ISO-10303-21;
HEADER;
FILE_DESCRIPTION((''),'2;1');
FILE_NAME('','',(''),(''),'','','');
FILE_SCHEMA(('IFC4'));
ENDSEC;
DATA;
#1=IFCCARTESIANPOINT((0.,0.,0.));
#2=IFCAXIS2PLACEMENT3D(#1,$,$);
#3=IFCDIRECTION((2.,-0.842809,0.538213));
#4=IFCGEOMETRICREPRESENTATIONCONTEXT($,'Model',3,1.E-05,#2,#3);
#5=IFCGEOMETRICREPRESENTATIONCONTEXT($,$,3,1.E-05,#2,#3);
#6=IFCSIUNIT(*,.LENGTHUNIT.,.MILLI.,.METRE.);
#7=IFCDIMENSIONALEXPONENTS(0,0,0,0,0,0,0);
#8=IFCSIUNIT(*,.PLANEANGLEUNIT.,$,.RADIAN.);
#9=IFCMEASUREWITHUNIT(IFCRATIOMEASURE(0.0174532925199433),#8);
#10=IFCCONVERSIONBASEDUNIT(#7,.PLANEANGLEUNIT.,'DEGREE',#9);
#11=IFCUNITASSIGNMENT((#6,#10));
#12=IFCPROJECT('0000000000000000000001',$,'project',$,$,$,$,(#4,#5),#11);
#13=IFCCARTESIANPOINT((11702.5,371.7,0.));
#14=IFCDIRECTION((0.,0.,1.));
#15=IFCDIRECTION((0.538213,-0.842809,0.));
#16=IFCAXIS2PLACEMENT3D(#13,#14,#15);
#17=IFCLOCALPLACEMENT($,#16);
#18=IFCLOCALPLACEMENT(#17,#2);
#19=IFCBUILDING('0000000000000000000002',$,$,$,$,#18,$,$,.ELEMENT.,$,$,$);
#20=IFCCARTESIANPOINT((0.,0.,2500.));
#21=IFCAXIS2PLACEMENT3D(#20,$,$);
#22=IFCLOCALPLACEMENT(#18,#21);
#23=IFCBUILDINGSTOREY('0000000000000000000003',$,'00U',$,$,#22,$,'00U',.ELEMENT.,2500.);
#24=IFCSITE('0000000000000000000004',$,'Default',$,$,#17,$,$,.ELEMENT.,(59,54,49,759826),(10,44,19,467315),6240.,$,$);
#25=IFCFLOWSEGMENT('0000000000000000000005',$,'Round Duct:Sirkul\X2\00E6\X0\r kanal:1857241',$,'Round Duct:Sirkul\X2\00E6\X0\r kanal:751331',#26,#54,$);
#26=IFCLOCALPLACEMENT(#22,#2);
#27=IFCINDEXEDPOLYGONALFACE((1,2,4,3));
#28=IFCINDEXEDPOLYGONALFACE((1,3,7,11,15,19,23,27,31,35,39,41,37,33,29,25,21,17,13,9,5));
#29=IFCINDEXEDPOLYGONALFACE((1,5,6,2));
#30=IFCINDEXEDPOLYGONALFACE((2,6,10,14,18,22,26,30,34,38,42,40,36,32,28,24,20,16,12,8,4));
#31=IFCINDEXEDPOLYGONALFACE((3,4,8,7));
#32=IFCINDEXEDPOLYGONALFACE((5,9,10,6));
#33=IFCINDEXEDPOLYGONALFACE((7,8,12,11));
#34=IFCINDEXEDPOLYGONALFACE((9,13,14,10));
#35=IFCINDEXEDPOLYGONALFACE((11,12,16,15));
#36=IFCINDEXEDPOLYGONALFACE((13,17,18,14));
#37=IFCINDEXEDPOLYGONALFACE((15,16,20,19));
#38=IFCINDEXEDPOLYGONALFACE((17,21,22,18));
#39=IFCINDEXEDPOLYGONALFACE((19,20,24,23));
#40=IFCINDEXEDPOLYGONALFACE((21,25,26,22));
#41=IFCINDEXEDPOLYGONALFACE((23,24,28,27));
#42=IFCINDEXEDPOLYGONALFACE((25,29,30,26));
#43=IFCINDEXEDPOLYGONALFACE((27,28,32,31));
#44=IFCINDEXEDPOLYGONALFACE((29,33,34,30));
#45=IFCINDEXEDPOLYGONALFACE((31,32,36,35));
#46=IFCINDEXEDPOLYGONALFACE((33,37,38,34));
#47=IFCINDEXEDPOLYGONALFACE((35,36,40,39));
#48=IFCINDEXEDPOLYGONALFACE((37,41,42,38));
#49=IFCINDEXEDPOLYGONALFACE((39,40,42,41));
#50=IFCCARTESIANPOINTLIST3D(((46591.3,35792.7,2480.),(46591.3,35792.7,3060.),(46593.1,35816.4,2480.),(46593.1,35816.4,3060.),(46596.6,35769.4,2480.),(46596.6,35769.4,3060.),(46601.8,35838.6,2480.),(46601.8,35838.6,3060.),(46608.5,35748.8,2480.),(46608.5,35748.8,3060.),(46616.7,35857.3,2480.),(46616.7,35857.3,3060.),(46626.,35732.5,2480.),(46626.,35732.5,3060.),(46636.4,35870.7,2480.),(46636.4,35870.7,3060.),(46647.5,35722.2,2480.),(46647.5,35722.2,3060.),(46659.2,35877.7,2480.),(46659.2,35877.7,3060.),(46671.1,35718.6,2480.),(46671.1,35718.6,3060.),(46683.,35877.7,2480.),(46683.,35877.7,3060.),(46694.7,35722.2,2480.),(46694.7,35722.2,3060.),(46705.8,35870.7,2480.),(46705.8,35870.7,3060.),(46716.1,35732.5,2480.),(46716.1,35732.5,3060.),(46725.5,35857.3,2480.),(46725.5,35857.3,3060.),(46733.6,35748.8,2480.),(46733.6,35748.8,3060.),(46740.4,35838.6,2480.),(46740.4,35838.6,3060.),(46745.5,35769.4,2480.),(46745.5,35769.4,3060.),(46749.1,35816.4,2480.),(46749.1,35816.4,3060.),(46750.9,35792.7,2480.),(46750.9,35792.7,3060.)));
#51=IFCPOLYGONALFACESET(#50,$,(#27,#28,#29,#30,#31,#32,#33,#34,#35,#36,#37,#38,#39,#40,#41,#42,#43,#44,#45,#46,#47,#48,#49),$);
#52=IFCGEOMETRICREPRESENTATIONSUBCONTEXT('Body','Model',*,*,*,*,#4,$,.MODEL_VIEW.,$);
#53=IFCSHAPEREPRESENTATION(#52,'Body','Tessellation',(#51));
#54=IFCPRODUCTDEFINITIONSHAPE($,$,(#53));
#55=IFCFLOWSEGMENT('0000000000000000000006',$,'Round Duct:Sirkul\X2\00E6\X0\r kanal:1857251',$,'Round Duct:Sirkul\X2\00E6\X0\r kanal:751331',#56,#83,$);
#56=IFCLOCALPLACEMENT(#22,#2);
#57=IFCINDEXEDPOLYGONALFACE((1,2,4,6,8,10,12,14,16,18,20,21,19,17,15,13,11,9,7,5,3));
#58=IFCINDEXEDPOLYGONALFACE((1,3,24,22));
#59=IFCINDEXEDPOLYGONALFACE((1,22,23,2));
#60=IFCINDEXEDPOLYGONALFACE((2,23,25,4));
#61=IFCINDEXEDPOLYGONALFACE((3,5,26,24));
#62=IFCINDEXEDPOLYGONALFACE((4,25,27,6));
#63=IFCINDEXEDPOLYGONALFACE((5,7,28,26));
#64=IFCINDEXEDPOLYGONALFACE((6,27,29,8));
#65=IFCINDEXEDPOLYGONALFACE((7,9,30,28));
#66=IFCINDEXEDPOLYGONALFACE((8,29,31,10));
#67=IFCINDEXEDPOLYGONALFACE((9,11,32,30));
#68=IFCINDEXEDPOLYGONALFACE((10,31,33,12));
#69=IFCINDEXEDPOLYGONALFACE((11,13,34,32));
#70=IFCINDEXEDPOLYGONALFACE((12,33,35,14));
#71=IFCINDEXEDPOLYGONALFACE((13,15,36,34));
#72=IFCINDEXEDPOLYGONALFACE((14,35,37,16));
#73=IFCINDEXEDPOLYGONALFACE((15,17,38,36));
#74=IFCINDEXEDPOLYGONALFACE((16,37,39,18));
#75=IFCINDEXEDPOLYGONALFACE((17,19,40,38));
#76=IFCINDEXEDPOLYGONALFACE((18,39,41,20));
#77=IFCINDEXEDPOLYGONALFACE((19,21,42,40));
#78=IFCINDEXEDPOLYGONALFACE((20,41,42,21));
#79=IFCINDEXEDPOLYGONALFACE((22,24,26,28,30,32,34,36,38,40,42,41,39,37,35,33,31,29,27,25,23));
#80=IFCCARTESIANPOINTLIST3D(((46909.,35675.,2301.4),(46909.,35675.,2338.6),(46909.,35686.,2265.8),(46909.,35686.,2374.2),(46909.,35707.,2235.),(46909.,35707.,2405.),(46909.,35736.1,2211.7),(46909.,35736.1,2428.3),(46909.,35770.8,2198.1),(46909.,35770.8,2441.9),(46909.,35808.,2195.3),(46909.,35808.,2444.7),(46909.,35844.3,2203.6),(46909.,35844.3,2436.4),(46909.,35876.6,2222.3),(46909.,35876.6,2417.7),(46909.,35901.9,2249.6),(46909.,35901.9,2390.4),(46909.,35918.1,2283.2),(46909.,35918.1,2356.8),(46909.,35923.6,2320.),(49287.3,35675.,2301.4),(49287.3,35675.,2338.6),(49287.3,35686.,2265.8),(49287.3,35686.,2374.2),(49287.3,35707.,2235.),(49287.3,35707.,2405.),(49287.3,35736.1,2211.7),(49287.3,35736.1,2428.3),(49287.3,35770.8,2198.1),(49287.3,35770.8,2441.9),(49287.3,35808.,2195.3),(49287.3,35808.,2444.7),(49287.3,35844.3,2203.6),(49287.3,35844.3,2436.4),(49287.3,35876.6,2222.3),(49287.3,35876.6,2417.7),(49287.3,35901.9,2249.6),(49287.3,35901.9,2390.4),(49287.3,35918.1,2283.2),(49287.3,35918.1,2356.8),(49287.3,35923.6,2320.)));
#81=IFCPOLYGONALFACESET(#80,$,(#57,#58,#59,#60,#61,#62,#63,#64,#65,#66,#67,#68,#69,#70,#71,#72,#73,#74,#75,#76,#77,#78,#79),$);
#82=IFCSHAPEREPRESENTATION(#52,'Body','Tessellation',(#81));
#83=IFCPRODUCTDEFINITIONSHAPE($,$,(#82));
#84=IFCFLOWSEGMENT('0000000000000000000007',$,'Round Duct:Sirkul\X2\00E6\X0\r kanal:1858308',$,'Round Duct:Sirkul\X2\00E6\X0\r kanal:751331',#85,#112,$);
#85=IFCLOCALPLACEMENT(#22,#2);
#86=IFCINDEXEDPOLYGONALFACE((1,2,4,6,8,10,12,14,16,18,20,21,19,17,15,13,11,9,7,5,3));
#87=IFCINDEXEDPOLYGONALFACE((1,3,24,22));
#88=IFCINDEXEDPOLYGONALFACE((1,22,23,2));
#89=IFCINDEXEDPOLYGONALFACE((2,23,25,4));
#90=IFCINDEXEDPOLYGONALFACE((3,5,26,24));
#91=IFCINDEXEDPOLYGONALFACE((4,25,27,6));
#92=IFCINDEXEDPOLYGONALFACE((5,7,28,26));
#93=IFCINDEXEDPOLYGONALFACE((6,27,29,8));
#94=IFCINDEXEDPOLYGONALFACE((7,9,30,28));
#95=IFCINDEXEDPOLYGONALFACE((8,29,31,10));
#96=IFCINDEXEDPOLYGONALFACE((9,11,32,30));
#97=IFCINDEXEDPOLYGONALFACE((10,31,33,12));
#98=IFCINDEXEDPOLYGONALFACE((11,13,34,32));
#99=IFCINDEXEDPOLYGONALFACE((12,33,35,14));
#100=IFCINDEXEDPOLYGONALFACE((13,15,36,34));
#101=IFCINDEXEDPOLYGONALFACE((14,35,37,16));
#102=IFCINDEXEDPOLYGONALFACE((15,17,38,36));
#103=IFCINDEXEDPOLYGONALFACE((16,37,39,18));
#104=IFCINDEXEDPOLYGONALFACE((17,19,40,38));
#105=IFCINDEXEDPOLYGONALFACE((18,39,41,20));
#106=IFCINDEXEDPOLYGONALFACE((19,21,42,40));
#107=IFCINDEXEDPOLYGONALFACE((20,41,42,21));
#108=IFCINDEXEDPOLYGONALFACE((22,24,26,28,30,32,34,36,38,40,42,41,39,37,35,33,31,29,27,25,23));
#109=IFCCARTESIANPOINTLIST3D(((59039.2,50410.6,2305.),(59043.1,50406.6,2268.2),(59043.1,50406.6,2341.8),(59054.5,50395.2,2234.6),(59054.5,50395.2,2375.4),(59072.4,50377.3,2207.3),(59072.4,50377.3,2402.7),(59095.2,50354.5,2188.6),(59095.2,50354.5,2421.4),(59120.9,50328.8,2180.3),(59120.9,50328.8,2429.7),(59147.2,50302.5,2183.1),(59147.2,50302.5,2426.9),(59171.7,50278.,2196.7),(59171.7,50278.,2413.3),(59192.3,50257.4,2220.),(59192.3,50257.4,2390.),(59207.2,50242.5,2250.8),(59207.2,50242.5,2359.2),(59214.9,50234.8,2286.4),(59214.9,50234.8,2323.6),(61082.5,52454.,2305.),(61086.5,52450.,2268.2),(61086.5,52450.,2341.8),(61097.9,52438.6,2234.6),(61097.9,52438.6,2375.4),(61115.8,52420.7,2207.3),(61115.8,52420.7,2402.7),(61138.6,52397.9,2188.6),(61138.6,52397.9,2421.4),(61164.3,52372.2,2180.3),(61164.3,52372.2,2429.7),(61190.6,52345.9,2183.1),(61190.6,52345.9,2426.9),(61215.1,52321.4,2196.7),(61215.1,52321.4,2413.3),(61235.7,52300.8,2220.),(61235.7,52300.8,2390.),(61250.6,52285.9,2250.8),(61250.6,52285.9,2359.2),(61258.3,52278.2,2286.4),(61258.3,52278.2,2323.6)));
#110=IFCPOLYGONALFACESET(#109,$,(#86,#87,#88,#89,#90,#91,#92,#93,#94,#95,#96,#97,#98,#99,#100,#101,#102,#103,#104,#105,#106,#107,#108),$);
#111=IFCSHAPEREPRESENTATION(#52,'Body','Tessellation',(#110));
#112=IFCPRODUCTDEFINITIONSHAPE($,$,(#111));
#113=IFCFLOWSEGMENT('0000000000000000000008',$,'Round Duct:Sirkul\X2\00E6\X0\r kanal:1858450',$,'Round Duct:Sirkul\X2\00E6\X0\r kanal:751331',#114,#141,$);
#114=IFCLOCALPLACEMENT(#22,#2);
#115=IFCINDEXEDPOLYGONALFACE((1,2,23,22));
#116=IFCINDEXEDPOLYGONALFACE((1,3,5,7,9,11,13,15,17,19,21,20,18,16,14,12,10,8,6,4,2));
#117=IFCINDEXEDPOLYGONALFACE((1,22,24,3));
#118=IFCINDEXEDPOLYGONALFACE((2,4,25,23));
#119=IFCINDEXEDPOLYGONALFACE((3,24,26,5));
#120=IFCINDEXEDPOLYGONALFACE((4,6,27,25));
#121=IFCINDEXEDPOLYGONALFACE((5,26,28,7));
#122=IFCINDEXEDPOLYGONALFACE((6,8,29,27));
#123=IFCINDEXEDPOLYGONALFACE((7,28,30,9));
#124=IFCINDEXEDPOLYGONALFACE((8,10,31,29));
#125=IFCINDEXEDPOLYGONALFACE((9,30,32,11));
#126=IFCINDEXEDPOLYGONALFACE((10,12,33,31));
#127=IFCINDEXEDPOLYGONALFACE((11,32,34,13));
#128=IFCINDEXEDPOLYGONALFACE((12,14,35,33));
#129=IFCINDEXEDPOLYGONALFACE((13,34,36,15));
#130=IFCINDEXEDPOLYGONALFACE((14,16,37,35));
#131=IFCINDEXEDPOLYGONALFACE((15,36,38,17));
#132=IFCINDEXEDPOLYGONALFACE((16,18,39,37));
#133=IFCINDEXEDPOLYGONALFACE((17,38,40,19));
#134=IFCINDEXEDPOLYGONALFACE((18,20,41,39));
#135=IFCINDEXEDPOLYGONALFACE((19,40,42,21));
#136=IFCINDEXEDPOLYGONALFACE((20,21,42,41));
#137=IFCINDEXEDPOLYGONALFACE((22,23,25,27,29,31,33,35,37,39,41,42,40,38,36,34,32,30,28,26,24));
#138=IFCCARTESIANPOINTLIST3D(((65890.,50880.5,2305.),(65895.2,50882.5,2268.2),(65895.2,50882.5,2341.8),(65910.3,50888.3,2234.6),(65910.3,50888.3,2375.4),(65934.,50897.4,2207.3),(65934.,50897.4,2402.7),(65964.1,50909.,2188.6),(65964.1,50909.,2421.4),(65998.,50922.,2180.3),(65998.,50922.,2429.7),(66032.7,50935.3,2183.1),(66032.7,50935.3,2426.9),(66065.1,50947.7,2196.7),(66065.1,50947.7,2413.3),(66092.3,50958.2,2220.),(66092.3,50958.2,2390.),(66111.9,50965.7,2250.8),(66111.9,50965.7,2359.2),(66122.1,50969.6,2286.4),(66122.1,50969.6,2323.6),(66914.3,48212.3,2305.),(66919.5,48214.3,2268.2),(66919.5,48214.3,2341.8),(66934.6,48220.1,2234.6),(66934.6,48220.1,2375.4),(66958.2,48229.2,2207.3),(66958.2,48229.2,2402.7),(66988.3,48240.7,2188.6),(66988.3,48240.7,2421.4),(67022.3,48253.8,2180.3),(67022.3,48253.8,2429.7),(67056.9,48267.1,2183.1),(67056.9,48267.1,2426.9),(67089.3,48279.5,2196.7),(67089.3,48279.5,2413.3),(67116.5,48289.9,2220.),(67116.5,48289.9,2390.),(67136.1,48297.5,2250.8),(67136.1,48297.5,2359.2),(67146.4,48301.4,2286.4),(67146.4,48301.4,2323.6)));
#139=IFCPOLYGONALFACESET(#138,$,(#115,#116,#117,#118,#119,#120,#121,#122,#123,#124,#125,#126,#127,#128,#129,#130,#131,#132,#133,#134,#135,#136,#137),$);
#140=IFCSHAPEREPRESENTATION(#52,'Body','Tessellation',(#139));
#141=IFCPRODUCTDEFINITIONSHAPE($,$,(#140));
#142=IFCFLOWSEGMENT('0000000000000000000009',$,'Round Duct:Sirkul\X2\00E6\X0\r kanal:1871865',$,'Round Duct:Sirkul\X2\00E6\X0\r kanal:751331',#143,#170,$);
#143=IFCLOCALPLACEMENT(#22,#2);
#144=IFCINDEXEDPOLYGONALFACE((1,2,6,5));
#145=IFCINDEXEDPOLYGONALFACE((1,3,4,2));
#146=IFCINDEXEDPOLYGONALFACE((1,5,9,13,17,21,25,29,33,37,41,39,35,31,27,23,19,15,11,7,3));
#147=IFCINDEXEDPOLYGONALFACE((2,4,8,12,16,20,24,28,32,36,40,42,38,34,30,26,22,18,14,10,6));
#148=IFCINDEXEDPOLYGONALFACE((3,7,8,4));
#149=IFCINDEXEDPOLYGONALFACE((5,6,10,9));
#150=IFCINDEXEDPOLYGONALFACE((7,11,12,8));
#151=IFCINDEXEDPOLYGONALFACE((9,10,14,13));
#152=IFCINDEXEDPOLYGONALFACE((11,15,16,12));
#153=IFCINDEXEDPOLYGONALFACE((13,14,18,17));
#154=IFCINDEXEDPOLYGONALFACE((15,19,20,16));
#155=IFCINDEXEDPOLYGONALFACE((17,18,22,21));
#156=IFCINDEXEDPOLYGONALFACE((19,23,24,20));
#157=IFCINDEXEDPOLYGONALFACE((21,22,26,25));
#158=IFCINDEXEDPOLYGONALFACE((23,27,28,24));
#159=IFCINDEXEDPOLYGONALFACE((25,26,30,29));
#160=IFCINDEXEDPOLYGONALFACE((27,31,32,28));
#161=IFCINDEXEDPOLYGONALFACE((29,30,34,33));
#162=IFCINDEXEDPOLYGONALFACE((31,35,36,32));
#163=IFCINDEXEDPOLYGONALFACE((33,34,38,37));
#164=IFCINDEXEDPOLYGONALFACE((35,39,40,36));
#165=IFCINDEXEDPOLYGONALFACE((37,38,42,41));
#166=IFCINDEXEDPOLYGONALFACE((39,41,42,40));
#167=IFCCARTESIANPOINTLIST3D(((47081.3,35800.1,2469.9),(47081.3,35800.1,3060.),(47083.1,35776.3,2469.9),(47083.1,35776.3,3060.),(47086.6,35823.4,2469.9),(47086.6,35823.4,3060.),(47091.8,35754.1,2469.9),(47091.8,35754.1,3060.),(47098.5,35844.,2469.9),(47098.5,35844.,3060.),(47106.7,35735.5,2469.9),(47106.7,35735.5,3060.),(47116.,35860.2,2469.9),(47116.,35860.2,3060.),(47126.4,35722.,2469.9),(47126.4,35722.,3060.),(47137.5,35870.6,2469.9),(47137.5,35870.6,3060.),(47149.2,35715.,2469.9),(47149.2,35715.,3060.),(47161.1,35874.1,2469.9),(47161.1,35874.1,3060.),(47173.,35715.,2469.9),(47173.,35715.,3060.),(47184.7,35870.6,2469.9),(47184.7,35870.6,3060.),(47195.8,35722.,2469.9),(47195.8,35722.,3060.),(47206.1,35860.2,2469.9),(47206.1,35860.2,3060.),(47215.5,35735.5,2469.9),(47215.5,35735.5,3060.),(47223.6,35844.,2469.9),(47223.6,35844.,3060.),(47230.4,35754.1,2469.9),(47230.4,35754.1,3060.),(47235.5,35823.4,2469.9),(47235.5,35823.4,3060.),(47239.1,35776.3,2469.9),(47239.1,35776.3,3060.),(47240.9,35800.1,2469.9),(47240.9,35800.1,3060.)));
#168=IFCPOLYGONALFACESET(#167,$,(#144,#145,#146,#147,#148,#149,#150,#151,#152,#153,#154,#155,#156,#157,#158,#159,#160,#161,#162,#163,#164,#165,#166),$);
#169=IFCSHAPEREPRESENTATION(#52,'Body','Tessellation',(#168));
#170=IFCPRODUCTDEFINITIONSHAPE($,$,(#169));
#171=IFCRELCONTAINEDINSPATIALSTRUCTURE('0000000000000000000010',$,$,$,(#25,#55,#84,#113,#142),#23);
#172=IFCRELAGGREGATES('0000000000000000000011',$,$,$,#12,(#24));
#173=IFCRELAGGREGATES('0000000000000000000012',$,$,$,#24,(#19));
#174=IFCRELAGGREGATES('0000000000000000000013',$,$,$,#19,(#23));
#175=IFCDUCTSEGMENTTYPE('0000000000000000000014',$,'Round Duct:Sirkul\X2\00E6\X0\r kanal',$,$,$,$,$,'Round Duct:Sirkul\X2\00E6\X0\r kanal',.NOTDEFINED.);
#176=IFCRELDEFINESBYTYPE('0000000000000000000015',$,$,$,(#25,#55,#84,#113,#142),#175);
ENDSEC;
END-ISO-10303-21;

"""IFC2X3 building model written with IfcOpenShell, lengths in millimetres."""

from ifc_helpers import new_model, entity, si_unit, converted_unit, direction, frame, origin, origin_2d_with_axis, place, context, subcontext, project, spatial, circle, extrude, type_object, element, save


model = new_model("IFC2X3")

# Units and contexts
model_context = context("Model", 3, precision=1e-05, world=origin(), true_north=direction((2.0, -0.842809, 0.538213)))
context_of_model = context(None, 3, precision=1e-05, world=origin(), true_north=direction((2.0, -0.842809, 0.538213)))
body_context = subcontext(model_context, "Body", "Model", "MODEL_VIEW")
ifc_project = project(units=[si_unit("LENGTHUNIT", "METRE", prefix="MILLI"), converted_unit("PLANEANGLEUNIT", "DEGREE", entity("IfcRatioMeasure", 0.0174532925199433), si_unit("PLANEANGLEUNIT", "RADIAN"), dimensions=[0, 0, 0, 0, 0, 0, 0])], contexts=[model_context, context_of_model])

# Site, building, storey
site_placement = place(None, frame((11702.5, 371.7, 0.0), z_axis=(0.0, 0.0, 1.0), x_axis=(0.538213, -0.842809, 0.0)))
site = spatial("IfcSite", under=ifc_project, at=site_placement, Name="Default", CompositionType="ELEMENT", RefLatitude=(59, 54, 49, 759826), RefLongitude=(10, 44, 19, 467315), RefElevation=6240.0)
building_placement = place(site_placement, origin())
building = spatial("IfcBuilding", under=site, at=building_placement, CompositionType="ELEMENT")
storey_placement = place(building_placement, frame((0.0, 0.0, 2500.0)))
storey = spatial("IfcBuildingStorey", under=building, at=storey_placement, Name="00U", LongName="00U", CompositionType="ELEMENT", Elevation=2500.0)

# Flow segments
duct_segment_type = type_object("IfcDuctSegmentType", Name="Round Duct:Sirkulær kanal", ElementType="Round Duct:Sirkulær kanal", PredefinedType="NOTDEFINED")
flow_segment_1_placement = place(storey_placement, origin())
element("IfcFlowSegment", 1, at=flow_segment_1_placement, inside=storey, type_object=duct_segment_type, Name="Round Duct:Sirkulær kanal:1857241", ObjectType="Round Duct:Sirkulær kanal:751331", context=body_context, shape_type="SweptSolid", body=[
    extrude(circle(Radius=80.0, at=origin_2d_with_axis()), frame((46671.1, 35798.6, 2480.0), z_axis=(0.0, 0.0, 1.0), x_axis=(0.0, -1.0, 0.0)), (0.0, 0.0, 1.0), 580.0),
])
flow_segment_2_placement = place(storey_placement, origin())
element("IfcFlowSegment", 2, at=flow_segment_2_placement, inside=storey, type_object=duct_segment_type, Name="Round Duct:Sirkulær kanal:1857251", ObjectType="Round Duct:Sirkulær kanal:751331", context=body_context, shape_type="SweptSolid", body=[
    extrude(circle(Radius=125.0, at=origin_2d_with_axis()), frame((46909.0, 35798.6, 2320.0), z_axis=(1.0, 0.0, 0.0), x_axis=(0.0, 1.0, 0.0)), (0.0, 0.0, 1.0), 2378.3),
])
flow_segment_3_placement = place(storey_placement, origin())
element("IfcFlowSegment", 3, at=flow_segment_3_placement, inside=storey, type_object=duct_segment_type, Name="Round Duct:Sirkulær kanal:1858308", ObjectType="Round Duct:Sirkulær kanal:751331", context=body_context, shape_type="SweptSolid", body=[
    extrude(circle(Radius=125.0, at=origin_2d_with_axis()), frame((59127.5, 50322.2, 2305.0), z_axis=(0.707107, 0.707107, 0.0), x_axis=(-0.707107, 0.707107, 0.0)), (0.0, 0.0, 1.0), 2889.8),
])
flow_segment_4_placement = place(storey_placement, origin())
element("IfcFlowSegment", 4, at=flow_segment_4_placement, inside=storey, type_object=duct_segment_type, Name="Round Duct:Sirkulær kanal:1858450", ObjectType="Round Duct:Sirkulær kanal:751331", context=body_context, shape_type="SweptSolid", body=[
    extrude(circle(Radius=125.0, at=origin_2d_with_axis()), frame((67031.0, 48257.1, 2305.0), z_axis=(-0.358368, 0.93358, 0.0), x_axis=(-0.93358, -0.358368, 0.0)), (0.0, 0.0, 1.0), 2858.1),
])
flow_segment_5_placement = place(storey_placement, origin())
element("IfcFlowSegment", 5, at=flow_segment_5_placement, inside=storey, type_object=duct_segment_type, Name="Round Duct:Sirkulær kanal:1871865", ObjectType="Round Duct:Sirkulær kanal:751331", context=body_context, shape_type="SweptSolid", body=[
    extrude(circle(Radius=80.0, at=origin_2d_with_axis()), frame((47161.1, 35794.1, 2469.9), z_axis=(0.0, 0.0, 1.0), x_axis=(0.0, 1.0, 0.0)), (0.0, 0.0, 1.0), 590.1),
])

save(model, "model.ifc")
